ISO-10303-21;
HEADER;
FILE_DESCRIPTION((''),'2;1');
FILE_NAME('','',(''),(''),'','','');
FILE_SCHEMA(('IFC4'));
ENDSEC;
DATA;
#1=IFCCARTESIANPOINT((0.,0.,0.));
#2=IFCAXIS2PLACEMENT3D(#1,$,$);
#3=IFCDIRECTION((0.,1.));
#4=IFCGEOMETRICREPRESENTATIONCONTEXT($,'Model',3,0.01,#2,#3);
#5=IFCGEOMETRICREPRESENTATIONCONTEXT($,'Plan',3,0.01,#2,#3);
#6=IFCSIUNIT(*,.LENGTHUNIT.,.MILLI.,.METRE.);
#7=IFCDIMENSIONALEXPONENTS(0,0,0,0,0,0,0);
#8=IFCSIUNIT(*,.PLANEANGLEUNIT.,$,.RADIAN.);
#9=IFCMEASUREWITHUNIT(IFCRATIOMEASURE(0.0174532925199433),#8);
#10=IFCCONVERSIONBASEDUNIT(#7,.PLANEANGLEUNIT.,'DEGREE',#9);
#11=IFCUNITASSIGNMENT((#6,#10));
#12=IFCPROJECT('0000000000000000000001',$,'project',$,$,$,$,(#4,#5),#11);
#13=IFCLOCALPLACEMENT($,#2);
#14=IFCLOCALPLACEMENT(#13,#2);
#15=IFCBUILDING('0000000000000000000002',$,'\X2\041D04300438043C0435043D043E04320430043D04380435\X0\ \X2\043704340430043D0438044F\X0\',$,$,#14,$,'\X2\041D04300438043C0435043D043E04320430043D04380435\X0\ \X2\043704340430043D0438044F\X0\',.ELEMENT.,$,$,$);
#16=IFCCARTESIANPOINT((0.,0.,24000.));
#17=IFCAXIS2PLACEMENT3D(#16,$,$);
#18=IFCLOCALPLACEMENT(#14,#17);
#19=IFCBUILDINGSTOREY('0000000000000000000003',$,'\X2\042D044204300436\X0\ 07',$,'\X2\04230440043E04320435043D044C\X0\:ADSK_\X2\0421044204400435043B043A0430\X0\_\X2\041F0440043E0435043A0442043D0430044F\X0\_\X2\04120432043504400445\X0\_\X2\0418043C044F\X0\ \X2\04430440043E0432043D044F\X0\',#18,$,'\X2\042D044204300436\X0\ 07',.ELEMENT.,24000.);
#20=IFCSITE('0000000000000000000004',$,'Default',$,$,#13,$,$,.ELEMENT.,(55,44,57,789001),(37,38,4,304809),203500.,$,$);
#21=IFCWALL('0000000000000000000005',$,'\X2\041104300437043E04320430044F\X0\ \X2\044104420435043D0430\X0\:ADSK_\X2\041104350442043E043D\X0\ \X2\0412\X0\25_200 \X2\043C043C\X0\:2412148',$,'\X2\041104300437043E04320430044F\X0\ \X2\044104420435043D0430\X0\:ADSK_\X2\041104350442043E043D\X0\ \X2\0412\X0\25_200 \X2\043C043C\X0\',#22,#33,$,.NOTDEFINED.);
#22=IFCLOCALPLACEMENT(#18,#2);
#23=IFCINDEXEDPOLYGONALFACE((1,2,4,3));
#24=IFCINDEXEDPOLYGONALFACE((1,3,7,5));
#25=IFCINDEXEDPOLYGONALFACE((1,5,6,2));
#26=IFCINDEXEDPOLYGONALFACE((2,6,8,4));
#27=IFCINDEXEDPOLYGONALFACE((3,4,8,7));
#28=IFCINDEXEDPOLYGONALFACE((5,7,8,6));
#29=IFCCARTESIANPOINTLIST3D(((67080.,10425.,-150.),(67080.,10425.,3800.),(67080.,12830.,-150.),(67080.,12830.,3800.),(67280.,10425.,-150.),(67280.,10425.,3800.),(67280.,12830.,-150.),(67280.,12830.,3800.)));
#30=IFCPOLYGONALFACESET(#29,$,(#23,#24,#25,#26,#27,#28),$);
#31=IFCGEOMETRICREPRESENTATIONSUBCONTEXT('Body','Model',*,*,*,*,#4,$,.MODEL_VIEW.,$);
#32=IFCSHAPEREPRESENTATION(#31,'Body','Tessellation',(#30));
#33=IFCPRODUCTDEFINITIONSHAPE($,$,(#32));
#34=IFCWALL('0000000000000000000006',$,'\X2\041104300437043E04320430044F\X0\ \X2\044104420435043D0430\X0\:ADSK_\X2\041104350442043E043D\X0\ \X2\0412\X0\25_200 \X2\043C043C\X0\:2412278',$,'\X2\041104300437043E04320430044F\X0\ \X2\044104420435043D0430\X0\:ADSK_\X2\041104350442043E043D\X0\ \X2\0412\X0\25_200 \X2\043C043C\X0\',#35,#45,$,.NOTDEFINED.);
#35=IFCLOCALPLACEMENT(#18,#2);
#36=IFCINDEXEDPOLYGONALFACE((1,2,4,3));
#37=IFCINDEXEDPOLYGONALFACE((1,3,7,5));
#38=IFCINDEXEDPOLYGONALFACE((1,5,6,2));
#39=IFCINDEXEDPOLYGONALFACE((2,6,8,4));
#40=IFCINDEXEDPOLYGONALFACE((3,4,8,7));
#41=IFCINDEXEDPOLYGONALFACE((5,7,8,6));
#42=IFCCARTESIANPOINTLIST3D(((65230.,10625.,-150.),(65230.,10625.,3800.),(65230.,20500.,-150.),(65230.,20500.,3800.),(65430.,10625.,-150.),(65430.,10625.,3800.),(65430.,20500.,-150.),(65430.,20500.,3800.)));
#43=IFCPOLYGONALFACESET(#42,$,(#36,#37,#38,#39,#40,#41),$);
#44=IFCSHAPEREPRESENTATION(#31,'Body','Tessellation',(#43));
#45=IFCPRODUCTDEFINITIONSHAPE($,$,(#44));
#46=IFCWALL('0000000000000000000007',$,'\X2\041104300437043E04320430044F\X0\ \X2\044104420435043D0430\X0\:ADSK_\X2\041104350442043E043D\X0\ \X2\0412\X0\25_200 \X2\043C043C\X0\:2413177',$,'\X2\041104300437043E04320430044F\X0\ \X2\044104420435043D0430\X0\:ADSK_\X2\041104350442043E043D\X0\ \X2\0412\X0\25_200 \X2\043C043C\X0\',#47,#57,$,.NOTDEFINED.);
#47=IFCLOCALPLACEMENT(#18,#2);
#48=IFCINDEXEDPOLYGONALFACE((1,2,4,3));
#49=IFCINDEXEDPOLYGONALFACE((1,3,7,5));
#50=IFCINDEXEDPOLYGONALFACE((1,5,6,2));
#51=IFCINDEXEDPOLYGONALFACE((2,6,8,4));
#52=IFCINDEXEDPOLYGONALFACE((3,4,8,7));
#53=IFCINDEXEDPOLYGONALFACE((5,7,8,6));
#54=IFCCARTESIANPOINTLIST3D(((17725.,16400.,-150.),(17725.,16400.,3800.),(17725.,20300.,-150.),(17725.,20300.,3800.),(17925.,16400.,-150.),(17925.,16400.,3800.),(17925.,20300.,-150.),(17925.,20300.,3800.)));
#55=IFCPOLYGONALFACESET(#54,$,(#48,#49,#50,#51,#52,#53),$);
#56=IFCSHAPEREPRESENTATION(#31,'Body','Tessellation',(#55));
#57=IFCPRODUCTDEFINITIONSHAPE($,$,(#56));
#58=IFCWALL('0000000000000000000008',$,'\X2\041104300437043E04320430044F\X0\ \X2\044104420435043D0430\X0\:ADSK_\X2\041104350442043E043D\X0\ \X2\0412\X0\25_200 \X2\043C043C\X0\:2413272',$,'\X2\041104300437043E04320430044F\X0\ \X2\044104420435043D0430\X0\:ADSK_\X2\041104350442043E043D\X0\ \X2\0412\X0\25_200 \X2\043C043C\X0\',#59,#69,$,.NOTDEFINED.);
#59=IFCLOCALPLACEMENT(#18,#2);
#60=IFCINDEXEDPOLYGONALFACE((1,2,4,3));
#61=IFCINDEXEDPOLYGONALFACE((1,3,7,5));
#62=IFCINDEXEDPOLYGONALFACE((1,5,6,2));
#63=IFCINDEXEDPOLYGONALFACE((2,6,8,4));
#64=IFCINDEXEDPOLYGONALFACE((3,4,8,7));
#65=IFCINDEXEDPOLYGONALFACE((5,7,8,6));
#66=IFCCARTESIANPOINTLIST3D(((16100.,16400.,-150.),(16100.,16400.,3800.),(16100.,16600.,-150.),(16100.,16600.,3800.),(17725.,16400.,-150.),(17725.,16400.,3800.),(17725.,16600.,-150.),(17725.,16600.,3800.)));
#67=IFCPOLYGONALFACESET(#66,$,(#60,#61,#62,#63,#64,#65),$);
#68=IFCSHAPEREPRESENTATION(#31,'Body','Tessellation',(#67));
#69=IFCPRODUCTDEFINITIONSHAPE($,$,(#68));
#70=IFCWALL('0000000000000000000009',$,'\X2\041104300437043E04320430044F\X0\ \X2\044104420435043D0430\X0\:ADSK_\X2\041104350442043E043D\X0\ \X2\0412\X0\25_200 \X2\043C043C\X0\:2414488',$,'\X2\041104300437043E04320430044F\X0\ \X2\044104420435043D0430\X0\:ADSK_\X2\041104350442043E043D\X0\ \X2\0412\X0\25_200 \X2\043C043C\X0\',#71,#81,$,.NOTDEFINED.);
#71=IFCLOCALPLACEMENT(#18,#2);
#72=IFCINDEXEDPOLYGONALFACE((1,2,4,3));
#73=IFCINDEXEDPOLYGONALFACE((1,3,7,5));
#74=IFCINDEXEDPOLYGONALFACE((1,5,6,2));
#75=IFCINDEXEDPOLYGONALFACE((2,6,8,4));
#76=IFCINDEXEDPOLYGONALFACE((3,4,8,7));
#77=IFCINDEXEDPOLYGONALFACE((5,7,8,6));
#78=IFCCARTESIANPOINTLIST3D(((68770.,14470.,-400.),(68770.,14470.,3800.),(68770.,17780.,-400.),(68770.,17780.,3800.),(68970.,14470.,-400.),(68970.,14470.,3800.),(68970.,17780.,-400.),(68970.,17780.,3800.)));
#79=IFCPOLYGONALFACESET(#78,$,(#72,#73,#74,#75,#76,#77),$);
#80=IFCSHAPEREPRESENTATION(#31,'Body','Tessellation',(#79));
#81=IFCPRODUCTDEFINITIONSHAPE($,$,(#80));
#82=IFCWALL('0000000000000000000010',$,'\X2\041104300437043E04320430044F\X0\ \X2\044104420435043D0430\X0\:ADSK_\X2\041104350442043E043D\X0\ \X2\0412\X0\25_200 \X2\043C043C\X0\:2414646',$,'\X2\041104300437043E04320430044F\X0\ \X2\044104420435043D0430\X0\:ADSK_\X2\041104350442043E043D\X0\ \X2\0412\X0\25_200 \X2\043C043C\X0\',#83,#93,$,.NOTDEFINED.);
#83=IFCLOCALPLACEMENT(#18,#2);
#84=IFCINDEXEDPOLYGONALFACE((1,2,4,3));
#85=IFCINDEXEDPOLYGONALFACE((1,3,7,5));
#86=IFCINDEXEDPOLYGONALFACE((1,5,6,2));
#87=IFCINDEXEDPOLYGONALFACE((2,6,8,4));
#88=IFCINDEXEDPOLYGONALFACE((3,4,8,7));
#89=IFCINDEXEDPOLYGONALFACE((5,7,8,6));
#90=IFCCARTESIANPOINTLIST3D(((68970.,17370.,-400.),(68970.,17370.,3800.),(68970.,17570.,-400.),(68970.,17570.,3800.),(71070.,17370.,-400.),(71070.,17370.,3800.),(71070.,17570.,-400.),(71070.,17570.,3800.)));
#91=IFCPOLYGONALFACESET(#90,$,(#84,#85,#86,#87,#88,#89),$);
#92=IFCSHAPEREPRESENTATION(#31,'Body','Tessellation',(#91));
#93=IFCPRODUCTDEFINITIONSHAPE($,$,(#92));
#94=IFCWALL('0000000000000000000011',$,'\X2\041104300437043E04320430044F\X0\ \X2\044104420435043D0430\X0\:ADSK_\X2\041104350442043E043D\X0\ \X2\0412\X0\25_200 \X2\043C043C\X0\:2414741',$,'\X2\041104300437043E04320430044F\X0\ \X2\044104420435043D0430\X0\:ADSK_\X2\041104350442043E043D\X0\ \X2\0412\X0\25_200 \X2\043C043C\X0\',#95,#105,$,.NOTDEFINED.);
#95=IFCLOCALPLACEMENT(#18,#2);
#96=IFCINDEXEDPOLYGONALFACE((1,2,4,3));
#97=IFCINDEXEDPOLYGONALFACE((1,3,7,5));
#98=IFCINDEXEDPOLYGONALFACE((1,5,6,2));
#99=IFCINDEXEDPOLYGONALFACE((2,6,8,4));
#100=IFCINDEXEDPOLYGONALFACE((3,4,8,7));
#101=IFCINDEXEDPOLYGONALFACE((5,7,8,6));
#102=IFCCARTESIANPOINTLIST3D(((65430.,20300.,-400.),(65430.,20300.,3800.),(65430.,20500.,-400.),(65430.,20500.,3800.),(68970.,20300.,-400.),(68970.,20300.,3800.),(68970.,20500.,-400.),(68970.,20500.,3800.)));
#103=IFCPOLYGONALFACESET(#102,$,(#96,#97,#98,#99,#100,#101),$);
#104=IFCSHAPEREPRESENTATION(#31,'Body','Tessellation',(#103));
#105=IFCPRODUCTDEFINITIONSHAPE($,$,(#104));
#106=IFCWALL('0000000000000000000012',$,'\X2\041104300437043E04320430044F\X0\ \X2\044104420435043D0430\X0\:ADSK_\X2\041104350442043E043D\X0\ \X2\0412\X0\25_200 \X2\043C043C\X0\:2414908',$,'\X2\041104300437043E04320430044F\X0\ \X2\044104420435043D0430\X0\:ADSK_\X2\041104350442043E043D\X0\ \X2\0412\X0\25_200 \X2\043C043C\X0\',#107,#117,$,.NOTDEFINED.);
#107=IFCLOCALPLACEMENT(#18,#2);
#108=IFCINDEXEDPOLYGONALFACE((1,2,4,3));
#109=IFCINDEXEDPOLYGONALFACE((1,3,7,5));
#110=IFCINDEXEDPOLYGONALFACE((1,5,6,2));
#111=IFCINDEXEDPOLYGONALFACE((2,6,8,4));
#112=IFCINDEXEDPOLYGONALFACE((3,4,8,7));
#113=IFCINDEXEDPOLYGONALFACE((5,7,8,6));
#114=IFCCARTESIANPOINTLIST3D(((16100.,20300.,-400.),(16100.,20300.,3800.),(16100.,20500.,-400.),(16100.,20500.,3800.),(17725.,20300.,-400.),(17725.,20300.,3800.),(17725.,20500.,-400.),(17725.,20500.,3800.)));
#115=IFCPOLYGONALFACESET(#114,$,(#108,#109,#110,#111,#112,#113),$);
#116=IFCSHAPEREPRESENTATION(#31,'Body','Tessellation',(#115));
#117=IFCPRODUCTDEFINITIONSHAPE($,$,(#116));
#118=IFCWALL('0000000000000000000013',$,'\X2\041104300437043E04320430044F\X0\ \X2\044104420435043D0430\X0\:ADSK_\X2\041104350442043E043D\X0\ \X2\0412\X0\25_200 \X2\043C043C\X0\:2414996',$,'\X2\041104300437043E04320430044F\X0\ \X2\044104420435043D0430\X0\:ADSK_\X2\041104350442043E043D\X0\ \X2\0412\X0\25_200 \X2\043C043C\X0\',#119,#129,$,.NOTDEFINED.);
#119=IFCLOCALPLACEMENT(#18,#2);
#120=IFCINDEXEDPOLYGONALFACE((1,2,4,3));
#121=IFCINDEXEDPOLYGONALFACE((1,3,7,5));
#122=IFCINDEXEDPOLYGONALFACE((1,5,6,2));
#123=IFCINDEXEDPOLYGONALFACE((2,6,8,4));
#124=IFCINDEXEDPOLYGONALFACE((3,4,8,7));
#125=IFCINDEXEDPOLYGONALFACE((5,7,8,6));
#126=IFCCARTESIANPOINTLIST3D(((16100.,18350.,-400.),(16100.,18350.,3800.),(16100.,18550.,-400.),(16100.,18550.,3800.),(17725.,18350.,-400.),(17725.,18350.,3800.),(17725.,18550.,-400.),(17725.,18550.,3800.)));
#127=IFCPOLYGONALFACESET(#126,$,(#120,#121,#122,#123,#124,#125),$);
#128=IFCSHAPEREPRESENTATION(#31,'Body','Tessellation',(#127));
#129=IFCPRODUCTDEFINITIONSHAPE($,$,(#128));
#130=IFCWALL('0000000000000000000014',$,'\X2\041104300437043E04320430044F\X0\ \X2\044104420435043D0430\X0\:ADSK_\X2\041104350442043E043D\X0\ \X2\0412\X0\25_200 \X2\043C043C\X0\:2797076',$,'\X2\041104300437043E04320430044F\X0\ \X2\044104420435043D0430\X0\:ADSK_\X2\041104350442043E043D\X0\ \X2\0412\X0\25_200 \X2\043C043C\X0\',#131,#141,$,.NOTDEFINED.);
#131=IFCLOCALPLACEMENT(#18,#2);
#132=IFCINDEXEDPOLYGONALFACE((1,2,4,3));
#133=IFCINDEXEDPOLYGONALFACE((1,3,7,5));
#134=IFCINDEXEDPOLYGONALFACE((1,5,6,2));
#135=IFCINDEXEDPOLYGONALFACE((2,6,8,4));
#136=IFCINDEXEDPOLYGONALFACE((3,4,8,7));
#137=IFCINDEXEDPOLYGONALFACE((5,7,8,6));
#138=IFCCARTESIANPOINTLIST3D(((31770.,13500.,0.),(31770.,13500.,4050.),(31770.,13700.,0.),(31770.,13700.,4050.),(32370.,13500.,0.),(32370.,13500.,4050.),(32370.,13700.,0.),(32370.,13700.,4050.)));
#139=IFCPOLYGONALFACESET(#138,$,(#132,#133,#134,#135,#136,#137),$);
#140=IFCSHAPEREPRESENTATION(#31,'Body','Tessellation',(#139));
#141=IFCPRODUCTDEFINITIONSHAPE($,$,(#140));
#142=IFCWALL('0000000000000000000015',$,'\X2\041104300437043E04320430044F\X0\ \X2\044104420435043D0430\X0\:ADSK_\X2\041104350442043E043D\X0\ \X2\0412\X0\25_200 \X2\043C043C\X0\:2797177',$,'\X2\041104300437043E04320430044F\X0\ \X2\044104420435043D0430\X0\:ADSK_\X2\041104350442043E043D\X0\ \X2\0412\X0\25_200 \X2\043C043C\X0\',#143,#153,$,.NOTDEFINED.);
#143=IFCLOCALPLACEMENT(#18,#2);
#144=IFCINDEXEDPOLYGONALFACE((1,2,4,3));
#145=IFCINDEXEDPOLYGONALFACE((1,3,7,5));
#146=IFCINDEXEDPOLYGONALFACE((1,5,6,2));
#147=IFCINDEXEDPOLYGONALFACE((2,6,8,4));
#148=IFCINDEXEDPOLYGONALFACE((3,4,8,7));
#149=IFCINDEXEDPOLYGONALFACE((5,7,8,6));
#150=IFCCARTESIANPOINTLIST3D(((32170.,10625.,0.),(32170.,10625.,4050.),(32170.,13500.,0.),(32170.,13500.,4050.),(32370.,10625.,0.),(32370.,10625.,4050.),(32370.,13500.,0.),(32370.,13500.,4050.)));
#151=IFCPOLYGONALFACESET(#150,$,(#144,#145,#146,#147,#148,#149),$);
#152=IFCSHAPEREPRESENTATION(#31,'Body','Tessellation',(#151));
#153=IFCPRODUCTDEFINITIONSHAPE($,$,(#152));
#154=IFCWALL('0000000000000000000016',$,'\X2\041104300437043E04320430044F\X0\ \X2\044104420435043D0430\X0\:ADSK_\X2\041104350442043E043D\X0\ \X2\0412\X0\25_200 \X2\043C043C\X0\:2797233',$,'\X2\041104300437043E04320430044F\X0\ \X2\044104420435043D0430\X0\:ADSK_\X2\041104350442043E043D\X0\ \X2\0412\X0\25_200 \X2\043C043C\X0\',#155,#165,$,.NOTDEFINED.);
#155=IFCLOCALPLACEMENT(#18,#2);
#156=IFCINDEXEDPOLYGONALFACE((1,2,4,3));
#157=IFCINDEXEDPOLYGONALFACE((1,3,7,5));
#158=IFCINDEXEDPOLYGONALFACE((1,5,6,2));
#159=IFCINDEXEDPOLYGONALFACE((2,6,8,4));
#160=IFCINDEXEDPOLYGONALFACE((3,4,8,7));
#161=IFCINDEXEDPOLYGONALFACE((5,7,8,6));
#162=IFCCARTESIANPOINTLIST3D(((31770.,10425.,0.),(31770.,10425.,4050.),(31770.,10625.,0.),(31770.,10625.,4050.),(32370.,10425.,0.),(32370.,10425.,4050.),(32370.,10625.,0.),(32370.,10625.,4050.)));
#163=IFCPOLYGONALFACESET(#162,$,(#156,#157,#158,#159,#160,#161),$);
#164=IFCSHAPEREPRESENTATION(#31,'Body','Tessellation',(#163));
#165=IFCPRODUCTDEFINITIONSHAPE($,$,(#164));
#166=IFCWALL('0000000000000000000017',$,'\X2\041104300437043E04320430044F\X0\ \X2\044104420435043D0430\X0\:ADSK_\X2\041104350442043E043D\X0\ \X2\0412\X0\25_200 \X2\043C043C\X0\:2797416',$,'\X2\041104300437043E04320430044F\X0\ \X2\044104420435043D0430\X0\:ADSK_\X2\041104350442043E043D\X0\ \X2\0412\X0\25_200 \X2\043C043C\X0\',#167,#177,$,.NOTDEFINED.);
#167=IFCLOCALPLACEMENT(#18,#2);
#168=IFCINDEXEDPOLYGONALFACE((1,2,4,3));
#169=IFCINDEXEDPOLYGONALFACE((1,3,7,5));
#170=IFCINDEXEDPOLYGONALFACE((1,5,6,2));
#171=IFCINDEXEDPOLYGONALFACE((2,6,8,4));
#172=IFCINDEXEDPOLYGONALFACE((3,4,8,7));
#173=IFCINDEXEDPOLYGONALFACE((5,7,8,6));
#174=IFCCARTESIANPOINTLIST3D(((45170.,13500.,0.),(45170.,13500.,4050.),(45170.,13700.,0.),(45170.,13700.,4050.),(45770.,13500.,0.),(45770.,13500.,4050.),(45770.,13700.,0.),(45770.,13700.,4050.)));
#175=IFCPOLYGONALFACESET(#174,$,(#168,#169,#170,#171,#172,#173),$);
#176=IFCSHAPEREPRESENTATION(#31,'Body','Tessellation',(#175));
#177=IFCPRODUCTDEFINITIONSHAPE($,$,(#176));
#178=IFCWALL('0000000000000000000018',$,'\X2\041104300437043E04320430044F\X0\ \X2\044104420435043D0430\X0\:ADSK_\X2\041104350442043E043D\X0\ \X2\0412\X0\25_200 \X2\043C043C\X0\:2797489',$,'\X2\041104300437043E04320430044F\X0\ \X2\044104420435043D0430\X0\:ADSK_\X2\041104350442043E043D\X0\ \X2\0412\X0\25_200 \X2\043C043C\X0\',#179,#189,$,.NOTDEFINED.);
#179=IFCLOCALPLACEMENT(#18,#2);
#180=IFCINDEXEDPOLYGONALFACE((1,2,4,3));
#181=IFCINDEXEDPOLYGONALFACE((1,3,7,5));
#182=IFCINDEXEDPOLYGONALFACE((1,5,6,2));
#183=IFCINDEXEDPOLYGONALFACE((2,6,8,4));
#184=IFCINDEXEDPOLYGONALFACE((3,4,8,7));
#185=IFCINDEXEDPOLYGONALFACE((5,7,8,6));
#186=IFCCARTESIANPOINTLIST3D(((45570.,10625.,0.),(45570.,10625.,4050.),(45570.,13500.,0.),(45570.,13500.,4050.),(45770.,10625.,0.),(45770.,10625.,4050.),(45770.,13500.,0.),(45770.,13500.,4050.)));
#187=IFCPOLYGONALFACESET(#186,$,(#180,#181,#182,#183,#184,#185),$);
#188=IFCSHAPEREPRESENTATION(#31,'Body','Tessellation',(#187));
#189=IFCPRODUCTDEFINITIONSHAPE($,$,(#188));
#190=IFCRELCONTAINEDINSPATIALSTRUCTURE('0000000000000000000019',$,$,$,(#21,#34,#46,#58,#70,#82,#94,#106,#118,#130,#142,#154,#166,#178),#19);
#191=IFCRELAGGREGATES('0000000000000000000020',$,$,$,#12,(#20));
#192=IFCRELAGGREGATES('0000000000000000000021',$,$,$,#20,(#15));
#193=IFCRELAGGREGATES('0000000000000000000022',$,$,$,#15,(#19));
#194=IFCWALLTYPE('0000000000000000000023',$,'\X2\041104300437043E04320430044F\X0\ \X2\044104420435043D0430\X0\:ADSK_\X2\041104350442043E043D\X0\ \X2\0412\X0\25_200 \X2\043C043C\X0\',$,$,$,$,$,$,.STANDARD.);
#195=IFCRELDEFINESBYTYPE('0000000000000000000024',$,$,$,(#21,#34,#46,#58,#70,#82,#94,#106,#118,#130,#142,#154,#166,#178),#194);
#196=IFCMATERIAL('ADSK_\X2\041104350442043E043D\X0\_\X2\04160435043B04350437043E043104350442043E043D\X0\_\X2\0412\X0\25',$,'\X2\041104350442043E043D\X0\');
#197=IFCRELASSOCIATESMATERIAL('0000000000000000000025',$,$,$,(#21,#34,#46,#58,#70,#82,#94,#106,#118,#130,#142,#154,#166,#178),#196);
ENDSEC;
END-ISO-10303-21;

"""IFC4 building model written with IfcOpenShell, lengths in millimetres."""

from ifc_helpers import new_model, entity, si_unit, converted_unit, direction, frame, origin, place, context, subcontext, project, spatial, indexed_curve, outline, extrude, material, type_object, element, save


model = new_model("IFC4")

# Units and contexts
model_context = context("Model", 3, precision=0.01, world=origin(), true_north=direction((0.0, 1.0)))
plan_context = context("Plan", 3, precision=0.01, world=origin(), true_north=direction((0.0, 1.0)))
body_context = subcontext(model_context, "Body", "Model", "MODEL_VIEW")
ifc_project = project(units=[si_unit("LENGTHUNIT", "METRE", prefix="MILLI"), converted_unit("PLANEANGLEUNIT", "DEGREE", entity("IfcRatioMeasure", 0.0174532925199433), si_unit("PLANEANGLEUNIT", "RADIAN"), dimensions=[0, 0, 0, 0, 0, 0, 0])], contexts=[model_context, plan_context])

# Site, building, storey
site_placement = place(None, origin())
site = spatial("IfcSite", under=ifc_project, at=site_placement, Name="Default", CompositionType="ELEMENT", RefLatitude=(55, 44, 57, 789001), RefLongitude=(37, 38, 4, 304809), RefElevation=203500.0)
building_placement = place(site_placement, origin())
building = spatial("IfcBuilding", under=site, at=building_placement, Name="Наименование здания", LongName="Наименование здания", CompositionType="ELEMENT")
storey_placement = place(building_placement, frame((0.0, 0.0, 24000.0)))
storey = spatial("IfcBuildingStorey", under=building, at=storey_placement, Name="Этаж 07", ObjectType="Уровень:ADSK_Стрелка_Проектная_Вверх_Имя уровня", LongName="Этаж 07", CompositionType="ELEMENT", Elevation=24000.0)

# Shared definitions
ifc_material = material(Name="ADSK_Бетон_Железобетон_В25", Category="Бетон")

# Walls
wall_type = type_object("IfcWallType", Name="Базовая стена:ADSK_Бетон В25_200 мм", PredefinedType="STANDARD")
wall_1_placement = place(storey_placement, frame((67180.0, 12830.0, -150.0), z_axis=(0.0, 0.0, 1.0), x_axis=(0.0, -1.0, 0.0)))
element("IfcWall", 1, at=wall_1_placement, inside=storey, type_object=wall_type, material=ifc_material, Name="Базовая стена:ADSK_Бетон В25_200 мм:2412148", ObjectType="Базовая стена:ADSK_Бетон В25_200 мм", PredefinedType="NOTDEFINED", context=body_context, shape_type="SweptSolid", body=[
    extrude(outline(indexed_curve([(2405.0, 100.0), (0.0, 100.0), (0.0, -100.0), (2405.0, -100.0), (2405.0, 100.0)], self_intersect=False)), origin(), (0.0, 0.0, 1.0), 3950.0),
])
wall_2_placement = place(storey_placement, frame((65330.0, 10625.0, -150.0), z_axis=(0.0, 0.0, 1.0), x_axis=(0.0, 1.0, 0.0)))
element("IfcWall", 2, at=wall_2_placement, inside=storey, type_object=wall_type, material=ifc_material, Name="Базовая стена:ADSK_Бетон В25_200 мм:2412278", ObjectType="Базовая стена:ADSK_Бетон В25_200 мм", PredefinedType="NOTDEFINED", context=body_context, shape_type="SweptSolid", body=[
    extrude(outline(indexed_curve([(9875.0, 100.0), (0.0, 100.0), (0.0, -100.0), (9875.0, -100.0), (9875.0, 100.0)], self_intersect=False)), origin(), (0.0, 0.0, 1.0), 3950.0),
])
wall_3_placement = place(storey_placement, frame((17825.0, 20300.0, -150.0), z_axis=(0.0, 0.0, 1.0), x_axis=(0.0, -1.0, 0.0)))
element("IfcWall", 3, at=wall_3_placement, inside=storey, type_object=wall_type, material=ifc_material, Name="Базовая стена:ADSK_Бетон В25_200 мм:2413177", ObjectType="Базовая стена:ADSK_Бетон В25_200 мм", PredefinedType="NOTDEFINED", context=body_context, shape_type="SweptSolid", body=[
    extrude(outline(indexed_curve([(3900.0, 100.0), (0.0, 100.0), (0.0, -100.0), (3900.0, -100.0), (3900.0, 100.0)], self_intersect=False)), origin(), (0.0, 0.0, 1.0), 3950.0),
])
wall_4_placement = place(storey_placement, frame((17725.0, 16500.0, -150.0), z_axis=(0.0, 0.0, 1.0), x_axis=(-1.0, 0.0, 0.0)))
element("IfcWall", 4, at=wall_4_placement, inside=storey, type_object=wall_type, material=ifc_material, Name="Базовая стена:ADSK_Бетон В25_200 мм:2413272", ObjectType="Базовая стена:ADSK_Бетон В25_200 мм", PredefinedType="NOTDEFINED", context=body_context, shape_type="SweptSolid", body=[
    extrude(outline(indexed_curve([(1625.0, 100.0), (0.0, 100.0), (0.0, -100.0), (1625.0, -100.0), (1625.0, 100.0)], self_intersect=False)), origin(), (0.0, 0.0, 1.0), 3950.0),
])
wall_5_placement = place(storey_placement, frame((68870.0, 17780.0, -400.0), z_axis=(0.0, 0.0, 1.0), x_axis=(0.0, -1.0, 0.0)))
element("IfcWall", 5, at=wall_5_placement, inside=storey, type_object=wall_type, material=ifc_material, Name="Базовая стена:ADSK_Бетон В25_200 мм:2414488", ObjectType="Базовая стена:ADSK_Бетон В25_200 мм", PredefinedType="NOTDEFINED", context=body_context, shape_type="SweptSolid", body=[
    extrude(outline(indexed_curve([(3310.0, 100.0), (0.0, 100.0), (0.0, -100.0), (3310.0, -100.0), (3310.0, 100.0)], self_intersect=False)), origin(), (0.0, 0.0, 1.0), 4200.0),
])
wall_6_placement = place(storey_placement, frame((68970.0, 17470.0, -400.0)))
element("IfcWall", 6, at=wall_6_placement, inside=storey, type_object=wall_type, material=ifc_material, Name="Базовая стена:ADSK_Бетон В25_200 мм:2414646", ObjectType="Базовая стена:ADSK_Бетон В25_200 мм", PredefinedType="NOTDEFINED", context=body_context, shape_type="SweptSolid", body=[
    extrude(outline(indexed_curve([(2100.0, 100.0), (0.0, 100.0), (0.0, -100.0), (2100.0, -100.0), (2100.0, 100.0)], self_intersect=False)), origin(), (0.0, 0.0, 1.0), 4200.0),
])
wall_7_placement = place(storey_placement, frame((65430.0, 20400.0, -400.0)))
element("IfcWall", 7, at=wall_7_placement, inside=storey, type_object=wall_type, material=ifc_material, Name="Базовая стена:ADSK_Бетон В25_200 мм:2414741", ObjectType="Базовая стена:ADSK_Бетон В25_200 мм", PredefinedType="NOTDEFINED", context=body_context, shape_type="SweptSolid", body=[
    extrude(outline(indexed_curve([(3540.0, 100.0), (0.0, 100.0), (0.0, -100.0), (3540.0, -100.0), (3540.0, 100.0)], self_intersect=False)), origin(), (0.0, 0.0, 1.0), 4200.0),
])
wall_8_placement = place(storey_placement, frame((16100.0, 20400.0, -400.0)))
element("IfcWall", 8, at=wall_8_placement, inside=storey, type_object=wall_type, material=ifc_material, Name="Базовая стена:ADSK_Бетон В25_200 мм:2414908", ObjectType="Базовая стена:ADSK_Бетон В25_200 мм", PredefinedType="NOTDEFINED", context=body_context, shape_type="SweptSolid", body=[
    extrude(outline(indexed_curve([(1625.0, 100.0), (0.0, 100.0), (0.0, -100.0), (1625.0, -100.0), (1625.0, 100.0)], self_intersect=False)), origin(), (0.0, 0.0, 1.0), 4200.0),
])
wall_9_placement = place(storey_placement, frame((16100.0, 18450.0, -400.0)))
element("IfcWall", 9, at=wall_9_placement, inside=storey, type_object=wall_type, material=ifc_material, Name="Базовая стена:ADSK_Бетон В25_200 мм:2414996", ObjectType="Базовая стена:ADSK_Бетон В25_200 мм", PredefinedType="NOTDEFINED", context=body_context, shape_type="SweptSolid", body=[
    extrude(outline(indexed_curve([(1625.0, 100.0), (0.0, 100.0), (0.0, -100.0), (1625.0, -100.0), (1625.0, 100.0)], self_intersect=False)), origin(), (0.0, 0.0, 1.0), 4200.0),
])
wall_10_placement = place(storey_placement, frame((31770.0, 13600.0, 0.0)))
element("IfcWall", 10, at=wall_10_placement, inside=storey, type_object=wall_type, material=ifc_material, Name="Базовая стена:ADSK_Бетон В25_200 мм:2797076", ObjectType="Базовая стена:ADSK_Бетон В25_200 мм", PredefinedType="NOTDEFINED", context=body_context, shape_type="SweptSolid", body=[
    extrude(outline(indexed_curve([(600.0, 100.0), (0.0, 100.0), (0.0, -100.0), (600.0, -100.0), (600.0, 100.0)], self_intersect=False)), origin(), (0.0, 0.0, 1.0), 4050.0),
])
wall_11_placement = place(storey_placement, frame((32270.0, 13500.0, 0.0), z_axis=(0.0, 0.0, 1.0), x_axis=(0.0, -1.0, 0.0)))
element("IfcWall", 11, at=wall_11_placement, inside=storey, type_object=wall_type, material=ifc_material, Name="Базовая стена:ADSK_Бетон В25_200 мм:2797177", ObjectType="Базовая стена:ADSK_Бетон В25_200 мм", PredefinedType="NOTDEFINED", context=body_context, shape_type="SweptSolid", body=[
    extrude(outline(indexed_curve([(2875.0, 100.0), (0.0, 100.0), (0.0, -100.0), (2875.0, -100.0), (2875.0, 100.0)], self_intersect=False)), origin(), (0.0, 0.0, 1.0), 4050.0),
])
wall_12_placement = place(storey_placement, frame((32370.0, 10525.0, 0.0), z_axis=(0.0, 0.0, 1.0), x_axis=(-1.0, 0.0, 0.0)))
element("IfcWall", 12, at=wall_12_placement, inside=storey, type_object=wall_type, material=ifc_material, Name="Базовая стена:ADSK_Бетон В25_200 мм:2797233", ObjectType="Базовая стена:ADSK_Бетон В25_200 мм", PredefinedType="NOTDEFINED", context=body_context, shape_type="SweptSolid", body=[
    extrude(outline(indexed_curve([(600.0, 100.0), (0.0, 100.0), (0.0, -100.0), (600.0, -100.0), (600.0, 100.0)], self_intersect=False)), origin(), (0.0, 0.0, 1.0), 4050.0),
])
wall_13_placement = place(storey_placement, frame((45170.0, 13600.0, 0.0)))
element("IfcWall", 13, at=wall_13_placement, inside=storey, type_object=wall_type, material=ifc_material, Name="Базовая стена:ADSK_Бетон В25_200 мм:2797416", ObjectType="Базовая стена:ADSK_Бетон В25_200 мм", PredefinedType="NOTDEFINED", context=body_context, shape_type="SweptSolid", body=[
    extrude(outline(indexed_curve([(600.0, 100.0), (0.0, 100.0), (0.0, -100.0), (600.0, -100.0), (600.0, 100.0)], self_intersect=False)), origin(), (0.0, 0.0, 1.0), 4050.0),
])
wall_14_placement = place(storey_placement, frame((45670.0, 13500.0, 0.0), z_axis=(0.0, 0.0, 1.0), x_axis=(0.0, -1.0, 0.0)))
element("IfcWall", 14, at=wall_14_placement, inside=storey, type_object=wall_type, material=ifc_material, Name="Базовая стена:ADSK_Бетон В25_200 мм:2797489", ObjectType="Базовая стена:ADSK_Бетон В25_200 мм", PredefinedType="NOTDEFINED", context=body_context, shape_type="SweptSolid", body=[
    extrude(outline(indexed_curve([(2875.0, 100.0), (0.0, 100.0), (0.0, -100.0), (2875.0, -100.0), (2875.0, 100.0)], self_intersect=False)), origin(), (0.0, 0.0, 1.0), 4050.0),
])

save(model, "model.ifc")
